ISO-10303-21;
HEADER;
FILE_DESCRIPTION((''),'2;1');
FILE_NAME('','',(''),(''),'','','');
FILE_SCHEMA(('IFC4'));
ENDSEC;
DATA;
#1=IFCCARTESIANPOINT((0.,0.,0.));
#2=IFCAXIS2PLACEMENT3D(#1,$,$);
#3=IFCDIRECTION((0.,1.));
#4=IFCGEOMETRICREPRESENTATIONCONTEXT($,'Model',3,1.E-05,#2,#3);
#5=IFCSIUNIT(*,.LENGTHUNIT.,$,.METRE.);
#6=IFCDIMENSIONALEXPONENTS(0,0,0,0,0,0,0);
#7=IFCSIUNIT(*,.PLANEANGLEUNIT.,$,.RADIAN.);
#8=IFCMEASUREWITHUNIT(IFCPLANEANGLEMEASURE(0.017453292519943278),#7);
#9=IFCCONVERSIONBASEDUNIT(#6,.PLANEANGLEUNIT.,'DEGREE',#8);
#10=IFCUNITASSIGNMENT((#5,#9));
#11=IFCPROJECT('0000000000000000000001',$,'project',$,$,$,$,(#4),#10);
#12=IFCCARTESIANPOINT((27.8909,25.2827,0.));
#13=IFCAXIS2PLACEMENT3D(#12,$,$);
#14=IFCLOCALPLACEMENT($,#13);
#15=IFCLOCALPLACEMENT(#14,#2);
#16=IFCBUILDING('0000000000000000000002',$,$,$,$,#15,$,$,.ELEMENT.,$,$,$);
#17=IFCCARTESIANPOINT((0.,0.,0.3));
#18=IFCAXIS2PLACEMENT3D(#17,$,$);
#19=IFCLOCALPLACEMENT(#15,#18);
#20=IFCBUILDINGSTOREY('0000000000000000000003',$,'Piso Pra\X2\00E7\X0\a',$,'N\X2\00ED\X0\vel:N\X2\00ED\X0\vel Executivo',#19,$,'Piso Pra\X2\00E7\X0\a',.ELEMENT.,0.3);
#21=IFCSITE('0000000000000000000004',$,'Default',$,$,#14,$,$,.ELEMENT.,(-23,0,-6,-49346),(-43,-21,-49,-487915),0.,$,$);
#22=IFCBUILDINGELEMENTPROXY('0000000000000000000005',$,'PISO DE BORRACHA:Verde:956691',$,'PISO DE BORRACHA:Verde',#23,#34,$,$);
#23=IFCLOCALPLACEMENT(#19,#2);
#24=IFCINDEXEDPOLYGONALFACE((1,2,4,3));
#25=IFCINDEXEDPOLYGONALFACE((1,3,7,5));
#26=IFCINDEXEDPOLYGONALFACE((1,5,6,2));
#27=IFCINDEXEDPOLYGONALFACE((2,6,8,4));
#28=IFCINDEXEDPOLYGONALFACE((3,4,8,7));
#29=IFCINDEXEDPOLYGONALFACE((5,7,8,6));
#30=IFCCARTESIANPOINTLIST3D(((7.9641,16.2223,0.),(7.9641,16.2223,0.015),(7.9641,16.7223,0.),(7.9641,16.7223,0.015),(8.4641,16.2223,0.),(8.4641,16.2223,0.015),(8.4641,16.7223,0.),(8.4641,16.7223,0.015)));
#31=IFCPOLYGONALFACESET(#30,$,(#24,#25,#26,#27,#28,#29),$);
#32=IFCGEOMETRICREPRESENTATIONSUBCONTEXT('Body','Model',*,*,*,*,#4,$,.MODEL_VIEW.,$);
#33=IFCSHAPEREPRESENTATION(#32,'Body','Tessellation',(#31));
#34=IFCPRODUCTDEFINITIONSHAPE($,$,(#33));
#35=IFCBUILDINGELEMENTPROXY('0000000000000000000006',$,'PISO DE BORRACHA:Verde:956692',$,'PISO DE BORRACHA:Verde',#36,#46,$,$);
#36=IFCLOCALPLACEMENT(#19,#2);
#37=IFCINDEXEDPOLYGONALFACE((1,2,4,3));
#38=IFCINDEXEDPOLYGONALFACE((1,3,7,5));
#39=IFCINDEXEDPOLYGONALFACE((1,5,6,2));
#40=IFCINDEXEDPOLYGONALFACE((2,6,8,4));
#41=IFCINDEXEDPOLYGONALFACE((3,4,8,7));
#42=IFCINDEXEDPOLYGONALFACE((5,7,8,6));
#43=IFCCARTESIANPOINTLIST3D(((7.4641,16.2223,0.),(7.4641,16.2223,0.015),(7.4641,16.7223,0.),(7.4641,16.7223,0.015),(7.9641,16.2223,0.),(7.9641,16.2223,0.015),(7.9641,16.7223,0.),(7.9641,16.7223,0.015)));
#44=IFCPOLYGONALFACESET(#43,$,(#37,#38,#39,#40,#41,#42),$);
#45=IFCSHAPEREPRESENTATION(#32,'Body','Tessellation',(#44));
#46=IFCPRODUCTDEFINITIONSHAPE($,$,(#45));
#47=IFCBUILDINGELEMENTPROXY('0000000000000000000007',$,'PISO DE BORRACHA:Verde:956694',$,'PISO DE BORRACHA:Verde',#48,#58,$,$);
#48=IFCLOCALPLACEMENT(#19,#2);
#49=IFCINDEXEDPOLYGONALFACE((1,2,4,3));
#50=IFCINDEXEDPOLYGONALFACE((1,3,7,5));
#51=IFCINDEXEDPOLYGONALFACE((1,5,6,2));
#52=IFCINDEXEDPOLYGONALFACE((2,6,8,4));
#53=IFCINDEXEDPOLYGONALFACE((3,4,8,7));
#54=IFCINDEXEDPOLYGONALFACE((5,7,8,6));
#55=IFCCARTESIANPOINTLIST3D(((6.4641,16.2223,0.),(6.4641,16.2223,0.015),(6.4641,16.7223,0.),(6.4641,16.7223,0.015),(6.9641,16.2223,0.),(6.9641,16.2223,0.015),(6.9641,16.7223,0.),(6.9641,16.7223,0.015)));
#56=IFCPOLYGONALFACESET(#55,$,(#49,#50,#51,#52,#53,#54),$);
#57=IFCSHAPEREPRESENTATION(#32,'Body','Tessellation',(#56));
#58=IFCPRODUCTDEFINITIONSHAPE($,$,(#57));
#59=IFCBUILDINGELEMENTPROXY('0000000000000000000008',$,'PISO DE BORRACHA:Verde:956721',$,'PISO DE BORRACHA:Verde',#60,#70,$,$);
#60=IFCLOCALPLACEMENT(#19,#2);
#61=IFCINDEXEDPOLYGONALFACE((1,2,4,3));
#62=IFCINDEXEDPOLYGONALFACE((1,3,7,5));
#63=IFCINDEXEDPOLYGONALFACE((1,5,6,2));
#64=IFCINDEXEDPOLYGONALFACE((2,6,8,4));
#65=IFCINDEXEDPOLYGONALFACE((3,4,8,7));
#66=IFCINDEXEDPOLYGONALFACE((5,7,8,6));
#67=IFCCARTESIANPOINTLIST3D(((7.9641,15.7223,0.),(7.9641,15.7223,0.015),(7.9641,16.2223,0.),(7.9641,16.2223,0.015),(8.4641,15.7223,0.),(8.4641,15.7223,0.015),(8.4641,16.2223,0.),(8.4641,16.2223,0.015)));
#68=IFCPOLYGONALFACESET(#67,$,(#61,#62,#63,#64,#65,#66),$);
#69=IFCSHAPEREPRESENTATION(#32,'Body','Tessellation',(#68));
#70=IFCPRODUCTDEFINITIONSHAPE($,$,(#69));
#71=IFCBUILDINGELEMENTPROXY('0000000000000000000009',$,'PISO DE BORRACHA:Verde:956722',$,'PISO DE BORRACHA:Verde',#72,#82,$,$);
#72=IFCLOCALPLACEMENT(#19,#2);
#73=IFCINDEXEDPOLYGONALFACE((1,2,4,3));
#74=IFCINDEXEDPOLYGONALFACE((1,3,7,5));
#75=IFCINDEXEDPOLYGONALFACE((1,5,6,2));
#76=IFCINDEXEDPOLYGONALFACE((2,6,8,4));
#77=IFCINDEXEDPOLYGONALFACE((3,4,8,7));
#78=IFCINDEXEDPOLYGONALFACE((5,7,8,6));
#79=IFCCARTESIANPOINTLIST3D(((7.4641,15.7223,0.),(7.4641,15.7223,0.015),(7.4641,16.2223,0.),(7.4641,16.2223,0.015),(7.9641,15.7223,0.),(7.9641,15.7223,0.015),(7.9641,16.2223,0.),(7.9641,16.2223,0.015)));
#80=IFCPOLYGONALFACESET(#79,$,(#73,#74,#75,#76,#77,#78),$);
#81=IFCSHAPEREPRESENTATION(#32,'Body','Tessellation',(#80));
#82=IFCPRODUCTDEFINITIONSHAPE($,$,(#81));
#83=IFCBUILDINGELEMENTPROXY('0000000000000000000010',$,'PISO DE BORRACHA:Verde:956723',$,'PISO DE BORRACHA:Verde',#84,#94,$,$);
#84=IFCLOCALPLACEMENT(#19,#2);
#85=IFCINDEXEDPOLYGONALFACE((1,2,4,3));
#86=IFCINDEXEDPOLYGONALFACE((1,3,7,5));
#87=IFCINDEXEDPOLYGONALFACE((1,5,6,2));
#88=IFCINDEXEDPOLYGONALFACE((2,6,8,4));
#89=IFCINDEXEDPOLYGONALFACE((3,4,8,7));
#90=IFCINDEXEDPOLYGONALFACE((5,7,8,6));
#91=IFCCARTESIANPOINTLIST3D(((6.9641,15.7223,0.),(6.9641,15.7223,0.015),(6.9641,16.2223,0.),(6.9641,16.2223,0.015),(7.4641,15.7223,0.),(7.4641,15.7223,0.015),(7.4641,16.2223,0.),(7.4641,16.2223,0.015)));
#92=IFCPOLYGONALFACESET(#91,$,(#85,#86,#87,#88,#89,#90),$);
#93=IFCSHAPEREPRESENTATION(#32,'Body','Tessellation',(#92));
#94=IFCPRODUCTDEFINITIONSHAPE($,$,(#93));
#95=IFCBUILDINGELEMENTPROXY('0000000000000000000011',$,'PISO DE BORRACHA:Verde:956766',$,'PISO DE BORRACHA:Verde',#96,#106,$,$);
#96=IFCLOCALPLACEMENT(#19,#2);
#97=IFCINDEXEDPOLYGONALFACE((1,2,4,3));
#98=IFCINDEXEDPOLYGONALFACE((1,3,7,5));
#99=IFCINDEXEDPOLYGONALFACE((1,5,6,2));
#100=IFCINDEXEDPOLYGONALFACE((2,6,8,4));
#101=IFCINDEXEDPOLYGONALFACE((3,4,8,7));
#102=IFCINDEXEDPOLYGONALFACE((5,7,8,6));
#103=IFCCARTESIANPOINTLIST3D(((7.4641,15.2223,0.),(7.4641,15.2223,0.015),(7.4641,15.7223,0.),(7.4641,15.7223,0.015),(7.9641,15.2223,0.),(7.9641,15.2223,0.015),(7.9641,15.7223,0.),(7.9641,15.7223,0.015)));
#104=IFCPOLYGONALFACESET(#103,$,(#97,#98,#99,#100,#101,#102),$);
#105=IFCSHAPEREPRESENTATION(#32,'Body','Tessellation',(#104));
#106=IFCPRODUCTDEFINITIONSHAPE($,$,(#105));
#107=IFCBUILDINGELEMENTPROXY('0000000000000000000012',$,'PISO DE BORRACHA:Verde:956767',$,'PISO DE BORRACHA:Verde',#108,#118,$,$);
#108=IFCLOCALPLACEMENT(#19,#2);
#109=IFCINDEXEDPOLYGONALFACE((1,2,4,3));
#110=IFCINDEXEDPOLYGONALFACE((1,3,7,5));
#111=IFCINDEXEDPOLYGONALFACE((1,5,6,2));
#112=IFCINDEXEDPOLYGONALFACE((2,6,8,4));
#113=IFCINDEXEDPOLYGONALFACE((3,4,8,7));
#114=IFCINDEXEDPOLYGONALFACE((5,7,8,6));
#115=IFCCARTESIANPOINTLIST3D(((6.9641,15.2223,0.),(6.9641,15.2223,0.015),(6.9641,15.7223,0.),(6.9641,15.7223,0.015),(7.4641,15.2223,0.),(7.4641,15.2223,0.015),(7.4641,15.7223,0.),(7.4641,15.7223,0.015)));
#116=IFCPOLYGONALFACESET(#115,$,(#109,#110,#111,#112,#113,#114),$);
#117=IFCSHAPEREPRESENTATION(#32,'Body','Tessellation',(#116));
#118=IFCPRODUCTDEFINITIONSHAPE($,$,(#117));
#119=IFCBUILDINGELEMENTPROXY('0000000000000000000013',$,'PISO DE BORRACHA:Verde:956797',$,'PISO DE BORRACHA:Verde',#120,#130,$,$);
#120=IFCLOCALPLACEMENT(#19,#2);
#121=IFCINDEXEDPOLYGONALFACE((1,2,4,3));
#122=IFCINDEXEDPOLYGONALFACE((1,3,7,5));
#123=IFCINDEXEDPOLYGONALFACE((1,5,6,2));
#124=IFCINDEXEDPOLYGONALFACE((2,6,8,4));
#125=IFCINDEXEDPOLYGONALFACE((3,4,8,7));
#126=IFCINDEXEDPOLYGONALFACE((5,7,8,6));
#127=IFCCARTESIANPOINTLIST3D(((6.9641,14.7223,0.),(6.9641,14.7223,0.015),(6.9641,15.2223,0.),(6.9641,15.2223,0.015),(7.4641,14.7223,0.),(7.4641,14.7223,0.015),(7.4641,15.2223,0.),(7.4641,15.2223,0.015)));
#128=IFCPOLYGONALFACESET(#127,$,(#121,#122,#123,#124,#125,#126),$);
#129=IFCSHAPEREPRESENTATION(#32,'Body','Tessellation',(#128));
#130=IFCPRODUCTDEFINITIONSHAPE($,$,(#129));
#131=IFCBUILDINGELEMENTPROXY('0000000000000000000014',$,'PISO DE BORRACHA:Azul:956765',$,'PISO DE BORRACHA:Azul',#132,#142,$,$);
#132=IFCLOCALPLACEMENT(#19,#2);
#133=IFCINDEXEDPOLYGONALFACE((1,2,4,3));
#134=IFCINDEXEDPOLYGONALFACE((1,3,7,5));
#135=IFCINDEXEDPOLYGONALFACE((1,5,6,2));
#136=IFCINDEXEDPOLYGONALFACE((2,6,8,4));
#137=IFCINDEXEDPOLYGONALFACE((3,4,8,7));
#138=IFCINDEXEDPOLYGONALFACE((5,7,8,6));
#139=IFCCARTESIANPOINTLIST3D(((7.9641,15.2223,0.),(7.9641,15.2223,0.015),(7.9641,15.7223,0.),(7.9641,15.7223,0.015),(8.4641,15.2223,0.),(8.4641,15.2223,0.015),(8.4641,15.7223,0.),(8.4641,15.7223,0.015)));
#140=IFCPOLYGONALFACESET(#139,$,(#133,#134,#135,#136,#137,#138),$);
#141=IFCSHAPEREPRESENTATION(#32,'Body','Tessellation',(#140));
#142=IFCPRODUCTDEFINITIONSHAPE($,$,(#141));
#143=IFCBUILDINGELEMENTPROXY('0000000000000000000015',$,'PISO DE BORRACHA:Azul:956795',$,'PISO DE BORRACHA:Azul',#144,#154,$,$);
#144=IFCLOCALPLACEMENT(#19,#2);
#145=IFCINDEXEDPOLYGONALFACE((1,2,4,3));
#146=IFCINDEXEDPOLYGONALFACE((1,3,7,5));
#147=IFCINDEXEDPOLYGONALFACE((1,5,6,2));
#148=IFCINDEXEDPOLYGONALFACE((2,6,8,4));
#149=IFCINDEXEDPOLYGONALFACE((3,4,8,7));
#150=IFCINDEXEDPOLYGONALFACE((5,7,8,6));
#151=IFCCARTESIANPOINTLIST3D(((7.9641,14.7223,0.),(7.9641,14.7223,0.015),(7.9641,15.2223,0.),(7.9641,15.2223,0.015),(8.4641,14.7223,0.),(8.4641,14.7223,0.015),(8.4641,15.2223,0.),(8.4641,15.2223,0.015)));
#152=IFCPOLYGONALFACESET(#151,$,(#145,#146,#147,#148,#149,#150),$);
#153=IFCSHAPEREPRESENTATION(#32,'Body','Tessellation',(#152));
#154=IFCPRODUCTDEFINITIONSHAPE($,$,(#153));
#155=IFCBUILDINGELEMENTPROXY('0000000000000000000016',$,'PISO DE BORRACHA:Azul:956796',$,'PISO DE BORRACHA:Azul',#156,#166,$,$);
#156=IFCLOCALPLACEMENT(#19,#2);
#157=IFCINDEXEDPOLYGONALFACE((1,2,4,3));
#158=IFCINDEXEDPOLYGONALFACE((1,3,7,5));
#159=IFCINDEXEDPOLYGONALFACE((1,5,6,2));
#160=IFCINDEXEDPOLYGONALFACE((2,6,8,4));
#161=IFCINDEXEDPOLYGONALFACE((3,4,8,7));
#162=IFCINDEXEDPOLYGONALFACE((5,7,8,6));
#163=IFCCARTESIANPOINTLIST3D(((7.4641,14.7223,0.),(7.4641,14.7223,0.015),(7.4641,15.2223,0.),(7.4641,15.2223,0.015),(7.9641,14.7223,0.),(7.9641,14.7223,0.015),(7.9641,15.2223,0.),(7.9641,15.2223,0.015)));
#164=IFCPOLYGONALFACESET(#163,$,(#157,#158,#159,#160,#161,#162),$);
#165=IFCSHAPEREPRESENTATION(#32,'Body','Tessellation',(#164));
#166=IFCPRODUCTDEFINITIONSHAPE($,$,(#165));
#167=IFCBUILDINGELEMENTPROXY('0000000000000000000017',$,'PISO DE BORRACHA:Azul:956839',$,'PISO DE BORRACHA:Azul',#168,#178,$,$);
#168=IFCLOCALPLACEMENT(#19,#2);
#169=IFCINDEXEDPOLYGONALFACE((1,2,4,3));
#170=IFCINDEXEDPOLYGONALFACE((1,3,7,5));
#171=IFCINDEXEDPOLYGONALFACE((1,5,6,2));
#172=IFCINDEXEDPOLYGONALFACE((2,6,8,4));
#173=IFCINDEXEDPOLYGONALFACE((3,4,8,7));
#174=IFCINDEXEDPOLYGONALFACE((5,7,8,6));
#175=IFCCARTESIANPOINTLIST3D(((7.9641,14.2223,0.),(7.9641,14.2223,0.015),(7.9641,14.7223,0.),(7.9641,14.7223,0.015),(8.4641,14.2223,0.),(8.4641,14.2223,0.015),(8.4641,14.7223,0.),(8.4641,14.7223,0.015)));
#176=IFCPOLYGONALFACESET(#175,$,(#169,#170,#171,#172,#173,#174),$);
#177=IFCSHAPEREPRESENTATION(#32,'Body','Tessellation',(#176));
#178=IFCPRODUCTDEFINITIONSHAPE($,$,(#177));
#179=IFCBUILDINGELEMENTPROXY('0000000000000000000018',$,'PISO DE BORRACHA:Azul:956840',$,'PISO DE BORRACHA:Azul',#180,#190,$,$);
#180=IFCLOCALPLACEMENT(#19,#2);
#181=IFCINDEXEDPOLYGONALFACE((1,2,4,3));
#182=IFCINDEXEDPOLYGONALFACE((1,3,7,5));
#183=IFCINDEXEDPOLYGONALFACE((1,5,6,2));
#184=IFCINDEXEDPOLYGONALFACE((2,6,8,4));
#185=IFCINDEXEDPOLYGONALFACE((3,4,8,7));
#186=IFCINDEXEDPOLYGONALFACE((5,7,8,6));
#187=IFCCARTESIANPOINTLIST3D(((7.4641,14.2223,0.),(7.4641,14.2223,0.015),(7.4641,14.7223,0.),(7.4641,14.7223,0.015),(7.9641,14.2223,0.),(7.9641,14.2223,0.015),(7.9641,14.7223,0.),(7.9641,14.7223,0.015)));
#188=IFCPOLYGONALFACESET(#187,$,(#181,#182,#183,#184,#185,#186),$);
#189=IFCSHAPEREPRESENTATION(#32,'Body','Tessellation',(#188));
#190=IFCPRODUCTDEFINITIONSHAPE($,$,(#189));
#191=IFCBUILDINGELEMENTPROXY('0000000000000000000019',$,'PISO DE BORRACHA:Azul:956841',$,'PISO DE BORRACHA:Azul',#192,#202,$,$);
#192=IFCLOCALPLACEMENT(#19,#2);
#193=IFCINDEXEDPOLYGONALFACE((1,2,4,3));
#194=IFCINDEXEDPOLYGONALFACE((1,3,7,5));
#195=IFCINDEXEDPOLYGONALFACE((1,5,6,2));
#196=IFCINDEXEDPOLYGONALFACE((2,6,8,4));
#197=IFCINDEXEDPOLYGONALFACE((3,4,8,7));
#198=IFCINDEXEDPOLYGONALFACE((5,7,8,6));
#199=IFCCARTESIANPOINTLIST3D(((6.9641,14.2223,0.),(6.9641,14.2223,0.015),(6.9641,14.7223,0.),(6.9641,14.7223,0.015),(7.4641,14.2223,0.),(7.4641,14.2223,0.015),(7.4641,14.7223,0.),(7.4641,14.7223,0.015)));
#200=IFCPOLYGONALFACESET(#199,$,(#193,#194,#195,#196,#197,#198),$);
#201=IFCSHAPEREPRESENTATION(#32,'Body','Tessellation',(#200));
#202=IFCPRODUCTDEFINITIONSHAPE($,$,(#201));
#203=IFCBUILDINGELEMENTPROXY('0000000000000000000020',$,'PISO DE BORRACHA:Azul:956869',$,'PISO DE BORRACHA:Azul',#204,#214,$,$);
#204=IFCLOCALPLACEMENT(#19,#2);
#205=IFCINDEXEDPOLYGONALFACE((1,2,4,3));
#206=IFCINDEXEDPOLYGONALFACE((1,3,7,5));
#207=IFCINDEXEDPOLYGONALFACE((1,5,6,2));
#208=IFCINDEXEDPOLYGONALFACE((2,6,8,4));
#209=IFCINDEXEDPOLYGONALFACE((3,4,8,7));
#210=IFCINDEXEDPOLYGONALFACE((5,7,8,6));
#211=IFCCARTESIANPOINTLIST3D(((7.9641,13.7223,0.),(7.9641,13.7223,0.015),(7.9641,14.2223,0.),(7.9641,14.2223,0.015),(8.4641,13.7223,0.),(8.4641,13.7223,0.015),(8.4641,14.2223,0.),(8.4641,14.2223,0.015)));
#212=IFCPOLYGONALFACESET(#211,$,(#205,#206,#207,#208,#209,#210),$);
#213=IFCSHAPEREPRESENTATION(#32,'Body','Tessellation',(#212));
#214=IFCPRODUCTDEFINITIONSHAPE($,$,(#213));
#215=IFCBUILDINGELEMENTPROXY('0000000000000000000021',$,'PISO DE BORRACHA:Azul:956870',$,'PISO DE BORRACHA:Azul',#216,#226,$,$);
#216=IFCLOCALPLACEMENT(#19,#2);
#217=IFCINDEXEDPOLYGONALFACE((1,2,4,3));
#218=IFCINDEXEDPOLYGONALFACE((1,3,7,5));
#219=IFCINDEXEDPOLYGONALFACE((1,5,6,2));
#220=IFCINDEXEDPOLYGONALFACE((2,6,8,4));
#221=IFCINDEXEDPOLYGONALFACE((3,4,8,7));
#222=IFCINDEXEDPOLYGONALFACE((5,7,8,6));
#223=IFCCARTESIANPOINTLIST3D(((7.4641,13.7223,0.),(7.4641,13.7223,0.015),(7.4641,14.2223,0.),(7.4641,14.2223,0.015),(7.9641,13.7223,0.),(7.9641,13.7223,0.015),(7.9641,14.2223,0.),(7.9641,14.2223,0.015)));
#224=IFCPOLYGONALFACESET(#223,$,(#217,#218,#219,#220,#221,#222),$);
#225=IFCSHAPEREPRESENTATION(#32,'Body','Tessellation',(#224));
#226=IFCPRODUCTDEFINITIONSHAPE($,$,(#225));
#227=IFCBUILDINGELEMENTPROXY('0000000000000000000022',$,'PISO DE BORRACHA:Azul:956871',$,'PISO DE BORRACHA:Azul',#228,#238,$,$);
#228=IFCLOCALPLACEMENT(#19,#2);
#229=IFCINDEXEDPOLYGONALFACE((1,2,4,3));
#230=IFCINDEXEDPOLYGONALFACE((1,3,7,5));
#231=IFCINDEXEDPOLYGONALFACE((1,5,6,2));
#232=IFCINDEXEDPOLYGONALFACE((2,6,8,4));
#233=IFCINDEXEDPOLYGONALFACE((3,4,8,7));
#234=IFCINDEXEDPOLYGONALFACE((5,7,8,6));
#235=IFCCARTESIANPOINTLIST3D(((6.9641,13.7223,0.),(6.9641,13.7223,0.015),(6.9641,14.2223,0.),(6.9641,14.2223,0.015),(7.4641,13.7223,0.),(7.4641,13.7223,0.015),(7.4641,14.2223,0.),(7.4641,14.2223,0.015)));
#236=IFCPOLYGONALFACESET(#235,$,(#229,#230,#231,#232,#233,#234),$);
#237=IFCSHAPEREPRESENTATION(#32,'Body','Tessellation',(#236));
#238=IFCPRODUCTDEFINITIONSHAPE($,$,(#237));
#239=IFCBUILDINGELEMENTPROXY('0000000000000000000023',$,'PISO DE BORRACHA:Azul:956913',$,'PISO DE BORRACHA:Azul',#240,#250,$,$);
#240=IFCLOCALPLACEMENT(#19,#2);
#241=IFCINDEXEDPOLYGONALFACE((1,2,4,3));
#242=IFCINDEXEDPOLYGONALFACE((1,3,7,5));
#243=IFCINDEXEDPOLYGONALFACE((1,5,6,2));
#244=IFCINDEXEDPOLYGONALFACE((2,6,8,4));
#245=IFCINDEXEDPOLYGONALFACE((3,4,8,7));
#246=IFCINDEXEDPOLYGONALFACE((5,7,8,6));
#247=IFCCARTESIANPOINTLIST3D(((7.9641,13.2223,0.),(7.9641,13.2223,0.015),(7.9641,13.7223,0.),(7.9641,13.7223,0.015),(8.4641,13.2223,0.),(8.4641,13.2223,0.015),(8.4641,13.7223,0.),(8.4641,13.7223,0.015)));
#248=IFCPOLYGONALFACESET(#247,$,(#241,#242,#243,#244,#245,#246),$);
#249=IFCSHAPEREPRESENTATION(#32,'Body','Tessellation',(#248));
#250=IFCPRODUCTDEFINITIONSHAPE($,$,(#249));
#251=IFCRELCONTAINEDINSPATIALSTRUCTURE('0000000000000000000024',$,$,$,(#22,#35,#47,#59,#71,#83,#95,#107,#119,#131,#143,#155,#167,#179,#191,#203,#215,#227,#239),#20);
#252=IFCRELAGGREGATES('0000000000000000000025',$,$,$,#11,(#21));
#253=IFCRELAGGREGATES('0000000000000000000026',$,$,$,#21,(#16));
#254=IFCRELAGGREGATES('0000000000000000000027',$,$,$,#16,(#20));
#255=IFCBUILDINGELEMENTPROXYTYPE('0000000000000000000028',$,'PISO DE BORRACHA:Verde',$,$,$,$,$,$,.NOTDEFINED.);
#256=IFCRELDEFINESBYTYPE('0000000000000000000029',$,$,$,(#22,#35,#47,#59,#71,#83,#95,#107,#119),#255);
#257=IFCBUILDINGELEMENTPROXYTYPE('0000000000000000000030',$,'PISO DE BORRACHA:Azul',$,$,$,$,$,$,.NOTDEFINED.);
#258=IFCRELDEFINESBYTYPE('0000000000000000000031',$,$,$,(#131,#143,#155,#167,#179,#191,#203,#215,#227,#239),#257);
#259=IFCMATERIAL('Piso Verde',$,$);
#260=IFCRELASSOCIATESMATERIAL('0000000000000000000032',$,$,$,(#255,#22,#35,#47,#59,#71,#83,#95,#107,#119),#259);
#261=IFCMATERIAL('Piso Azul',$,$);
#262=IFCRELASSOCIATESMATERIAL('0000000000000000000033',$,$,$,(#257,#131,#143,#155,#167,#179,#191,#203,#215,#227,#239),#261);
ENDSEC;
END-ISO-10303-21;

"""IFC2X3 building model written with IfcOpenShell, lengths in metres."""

from ifc_helpers import new_model, entity, si_unit, converted_unit, direction, frame, origin, origin_2d_with_axis, place, context, subcontext, project, spatial, rectangle, extrude, source, transform, mapped, material, type_object, type_shapes, element, save


model = new_model("IFC2X3")

# Units and contexts
model_context = context("Model", 3, precision=1e-05, world=origin(), true_north=direction((0.0, 1.0)))
body_context = subcontext(model_context, "Body", "Model", "MODEL_VIEW")
ifc_project = project(units=[si_unit("LENGTHUNIT", "METRE"), converted_unit("PLANEANGLEUNIT", "DEGREE", entity("IfcPlaneAngleMeasure", 0.017453292519943278), si_unit("PLANEANGLEUNIT", "RADIAN"), dimensions=[0, 0, 0, 0, 0, 0, 0])], contexts=[model_context])

# Site, building, storey
site_placement = place(None, frame((27.8909, 25.2827, 0.0)))
site = spatial("IfcSite", under=ifc_project, at=site_placement, Name="Default", CompositionType="ELEMENT", RefLatitude=(-23, 0, -6, -49346), RefLongitude=(-43, -21, -49, -487915), RefElevation=0.0)
building_placement = place(site_placement, origin())
building = spatial("IfcBuilding", under=site, at=building_placement, CompositionType="ELEMENT")
storey_placement = place(building_placement, frame((0.0, 0.0, 0.3)))
storey = spatial("IfcBuildingStorey", under=building, at=storey_placement, Name="Piso Praça", ObjectType="Nível:Nível Executivo", LongName="Piso Praça", CompositionType="ELEMENT", Elevation=0.3)

# Building element proxies
ifc_material_1 = material(Name="Piso Verde")
building_element_proxy_type_1 = type_object("IfcBuildingElementProxyType", Name="PISO DE BORRACHA:Verde", PredefinedType="NOTDEFINED", material=ifc_material_1)
shared_shape_1 = source(origin(), body_context, "Body", "SweptSolid", [
    extrude(rectangle(XDim=0.5, YDim=0.5, at=origin_2d_with_axis()), frame((0.25, 0.25, 0.0), z_axis=(0.0, 0.0, 1.0), x_axis=(-1.0, 0.0, 0.0)), (0.0, 0.0, 1.0), 0.015),
])
type_shapes(building_element_proxy_type_1, [shared_shape_1])
for number, where, name in (
    (1, (7.9641, 16.2223, 0.0), "PISO DE BORRACHA:Verde:956691"),
    (2, (7.4641, 16.2223, 0.0), "PISO DE BORRACHA:Verde:956692"),
    (3, (6.4641, 16.2223, 0.0), "PISO DE BORRACHA:Verde:956694"),
    (4, (7.9641, 15.7223, 0.0), "PISO DE BORRACHA:Verde:956721"),
    (5, (7.4641, 15.7223, 0.0), "PISO DE BORRACHA:Verde:956722"),
    (6, (6.9641, 15.7223, 0.0), "PISO DE BORRACHA:Verde:956723"),
    (7, (7.4641, 15.2223, 0.0), "PISO DE BORRACHA:Verde:956766"),
    (8, (6.9641, 15.2223, 0.0), "PISO DE BORRACHA:Verde:956767"),
    (9, (6.9641, 14.7223, 0.0), "PISO DE BORRACHA:Verde:956797"),
):
    element("IfcBuildingElementProxy", number, at=place(storey_placement, frame(where)), inside=storey, type_object=building_element_proxy_type_1, material=ifc_material_1, Name=name, ObjectType="PISO DE BORRACHA:Verde", context=body_context, shape_type="MappedRepresentation", body=[
        mapped(shared_shape_1, transform((0.0, 0.0, 0.0), scale=1.0)),
    ])
ifc_material_2 = material(Name="Piso Azul")
building_element_proxy_type_2 = type_object("IfcBuildingElementProxyType", Name="PISO DE BORRACHA:Azul", PredefinedType="NOTDEFINED", material=ifc_material_2)
shared_shape_2 = source(origin(), body_context, "Body", "SweptSolid", [
    extrude(rectangle(XDim=0.5, YDim=0.5, at=origin_2d_with_axis()), frame((0.25, 0.25, 0.0), z_axis=(0.0, 0.0, 1.0), x_axis=(-1.0, 0.0, 0.0)), (0.0, 0.0, 1.0), 0.015),
])
type_shapes(building_element_proxy_type_2, [shared_shape_2])
for number, where, name in (
    (10, (7.9641, 15.2223, 0.0), "PISO DE BORRACHA:Azul:956765"),
    (11, (7.9641, 14.7223, 0.0), "PISO DE BORRACHA:Azul:956795"),
    (12, (7.4641, 14.7223, 0.0), "PISO DE BORRACHA:Azul:956796"),
    (13, (7.9641, 14.2223, 0.0), "PISO DE BORRACHA:Azul:956839"),
    (14, (7.4641, 14.2223, 0.0), "PISO DE BORRACHA:Azul:956840"),
    (15, (6.9641, 14.2223, 0.0), "PISO DE BORRACHA:Azul:956841"),
    (16, (7.9641, 13.7223, 0.0), "PISO DE BORRACHA:Azul:956869"),
    (17, (7.4641, 13.7223, 0.0), "PISO DE BORRACHA:Azul:956870"),
    (18, (6.9641, 13.7223, 0.0), "PISO DE BORRACHA:Azul:956871"),
    (19, (7.9641, 13.2223, 0.0), "PISO DE BORRACHA:Azul:956913"),
):
    element("IfcBuildingElementProxy", number, at=place(storey_placement, frame(where)), inside=storey, type_object=building_element_proxy_type_2, material=ifc_material_2, Name=name, ObjectType="PISO DE BORRACHA:Azul", context=body_context, shape_type="MappedRepresentation", body=[
        mapped(shared_shape_2, transform((0.0, 0.0, 0.0), scale=1.0)),
    ])

save(model, "model.ifc")
